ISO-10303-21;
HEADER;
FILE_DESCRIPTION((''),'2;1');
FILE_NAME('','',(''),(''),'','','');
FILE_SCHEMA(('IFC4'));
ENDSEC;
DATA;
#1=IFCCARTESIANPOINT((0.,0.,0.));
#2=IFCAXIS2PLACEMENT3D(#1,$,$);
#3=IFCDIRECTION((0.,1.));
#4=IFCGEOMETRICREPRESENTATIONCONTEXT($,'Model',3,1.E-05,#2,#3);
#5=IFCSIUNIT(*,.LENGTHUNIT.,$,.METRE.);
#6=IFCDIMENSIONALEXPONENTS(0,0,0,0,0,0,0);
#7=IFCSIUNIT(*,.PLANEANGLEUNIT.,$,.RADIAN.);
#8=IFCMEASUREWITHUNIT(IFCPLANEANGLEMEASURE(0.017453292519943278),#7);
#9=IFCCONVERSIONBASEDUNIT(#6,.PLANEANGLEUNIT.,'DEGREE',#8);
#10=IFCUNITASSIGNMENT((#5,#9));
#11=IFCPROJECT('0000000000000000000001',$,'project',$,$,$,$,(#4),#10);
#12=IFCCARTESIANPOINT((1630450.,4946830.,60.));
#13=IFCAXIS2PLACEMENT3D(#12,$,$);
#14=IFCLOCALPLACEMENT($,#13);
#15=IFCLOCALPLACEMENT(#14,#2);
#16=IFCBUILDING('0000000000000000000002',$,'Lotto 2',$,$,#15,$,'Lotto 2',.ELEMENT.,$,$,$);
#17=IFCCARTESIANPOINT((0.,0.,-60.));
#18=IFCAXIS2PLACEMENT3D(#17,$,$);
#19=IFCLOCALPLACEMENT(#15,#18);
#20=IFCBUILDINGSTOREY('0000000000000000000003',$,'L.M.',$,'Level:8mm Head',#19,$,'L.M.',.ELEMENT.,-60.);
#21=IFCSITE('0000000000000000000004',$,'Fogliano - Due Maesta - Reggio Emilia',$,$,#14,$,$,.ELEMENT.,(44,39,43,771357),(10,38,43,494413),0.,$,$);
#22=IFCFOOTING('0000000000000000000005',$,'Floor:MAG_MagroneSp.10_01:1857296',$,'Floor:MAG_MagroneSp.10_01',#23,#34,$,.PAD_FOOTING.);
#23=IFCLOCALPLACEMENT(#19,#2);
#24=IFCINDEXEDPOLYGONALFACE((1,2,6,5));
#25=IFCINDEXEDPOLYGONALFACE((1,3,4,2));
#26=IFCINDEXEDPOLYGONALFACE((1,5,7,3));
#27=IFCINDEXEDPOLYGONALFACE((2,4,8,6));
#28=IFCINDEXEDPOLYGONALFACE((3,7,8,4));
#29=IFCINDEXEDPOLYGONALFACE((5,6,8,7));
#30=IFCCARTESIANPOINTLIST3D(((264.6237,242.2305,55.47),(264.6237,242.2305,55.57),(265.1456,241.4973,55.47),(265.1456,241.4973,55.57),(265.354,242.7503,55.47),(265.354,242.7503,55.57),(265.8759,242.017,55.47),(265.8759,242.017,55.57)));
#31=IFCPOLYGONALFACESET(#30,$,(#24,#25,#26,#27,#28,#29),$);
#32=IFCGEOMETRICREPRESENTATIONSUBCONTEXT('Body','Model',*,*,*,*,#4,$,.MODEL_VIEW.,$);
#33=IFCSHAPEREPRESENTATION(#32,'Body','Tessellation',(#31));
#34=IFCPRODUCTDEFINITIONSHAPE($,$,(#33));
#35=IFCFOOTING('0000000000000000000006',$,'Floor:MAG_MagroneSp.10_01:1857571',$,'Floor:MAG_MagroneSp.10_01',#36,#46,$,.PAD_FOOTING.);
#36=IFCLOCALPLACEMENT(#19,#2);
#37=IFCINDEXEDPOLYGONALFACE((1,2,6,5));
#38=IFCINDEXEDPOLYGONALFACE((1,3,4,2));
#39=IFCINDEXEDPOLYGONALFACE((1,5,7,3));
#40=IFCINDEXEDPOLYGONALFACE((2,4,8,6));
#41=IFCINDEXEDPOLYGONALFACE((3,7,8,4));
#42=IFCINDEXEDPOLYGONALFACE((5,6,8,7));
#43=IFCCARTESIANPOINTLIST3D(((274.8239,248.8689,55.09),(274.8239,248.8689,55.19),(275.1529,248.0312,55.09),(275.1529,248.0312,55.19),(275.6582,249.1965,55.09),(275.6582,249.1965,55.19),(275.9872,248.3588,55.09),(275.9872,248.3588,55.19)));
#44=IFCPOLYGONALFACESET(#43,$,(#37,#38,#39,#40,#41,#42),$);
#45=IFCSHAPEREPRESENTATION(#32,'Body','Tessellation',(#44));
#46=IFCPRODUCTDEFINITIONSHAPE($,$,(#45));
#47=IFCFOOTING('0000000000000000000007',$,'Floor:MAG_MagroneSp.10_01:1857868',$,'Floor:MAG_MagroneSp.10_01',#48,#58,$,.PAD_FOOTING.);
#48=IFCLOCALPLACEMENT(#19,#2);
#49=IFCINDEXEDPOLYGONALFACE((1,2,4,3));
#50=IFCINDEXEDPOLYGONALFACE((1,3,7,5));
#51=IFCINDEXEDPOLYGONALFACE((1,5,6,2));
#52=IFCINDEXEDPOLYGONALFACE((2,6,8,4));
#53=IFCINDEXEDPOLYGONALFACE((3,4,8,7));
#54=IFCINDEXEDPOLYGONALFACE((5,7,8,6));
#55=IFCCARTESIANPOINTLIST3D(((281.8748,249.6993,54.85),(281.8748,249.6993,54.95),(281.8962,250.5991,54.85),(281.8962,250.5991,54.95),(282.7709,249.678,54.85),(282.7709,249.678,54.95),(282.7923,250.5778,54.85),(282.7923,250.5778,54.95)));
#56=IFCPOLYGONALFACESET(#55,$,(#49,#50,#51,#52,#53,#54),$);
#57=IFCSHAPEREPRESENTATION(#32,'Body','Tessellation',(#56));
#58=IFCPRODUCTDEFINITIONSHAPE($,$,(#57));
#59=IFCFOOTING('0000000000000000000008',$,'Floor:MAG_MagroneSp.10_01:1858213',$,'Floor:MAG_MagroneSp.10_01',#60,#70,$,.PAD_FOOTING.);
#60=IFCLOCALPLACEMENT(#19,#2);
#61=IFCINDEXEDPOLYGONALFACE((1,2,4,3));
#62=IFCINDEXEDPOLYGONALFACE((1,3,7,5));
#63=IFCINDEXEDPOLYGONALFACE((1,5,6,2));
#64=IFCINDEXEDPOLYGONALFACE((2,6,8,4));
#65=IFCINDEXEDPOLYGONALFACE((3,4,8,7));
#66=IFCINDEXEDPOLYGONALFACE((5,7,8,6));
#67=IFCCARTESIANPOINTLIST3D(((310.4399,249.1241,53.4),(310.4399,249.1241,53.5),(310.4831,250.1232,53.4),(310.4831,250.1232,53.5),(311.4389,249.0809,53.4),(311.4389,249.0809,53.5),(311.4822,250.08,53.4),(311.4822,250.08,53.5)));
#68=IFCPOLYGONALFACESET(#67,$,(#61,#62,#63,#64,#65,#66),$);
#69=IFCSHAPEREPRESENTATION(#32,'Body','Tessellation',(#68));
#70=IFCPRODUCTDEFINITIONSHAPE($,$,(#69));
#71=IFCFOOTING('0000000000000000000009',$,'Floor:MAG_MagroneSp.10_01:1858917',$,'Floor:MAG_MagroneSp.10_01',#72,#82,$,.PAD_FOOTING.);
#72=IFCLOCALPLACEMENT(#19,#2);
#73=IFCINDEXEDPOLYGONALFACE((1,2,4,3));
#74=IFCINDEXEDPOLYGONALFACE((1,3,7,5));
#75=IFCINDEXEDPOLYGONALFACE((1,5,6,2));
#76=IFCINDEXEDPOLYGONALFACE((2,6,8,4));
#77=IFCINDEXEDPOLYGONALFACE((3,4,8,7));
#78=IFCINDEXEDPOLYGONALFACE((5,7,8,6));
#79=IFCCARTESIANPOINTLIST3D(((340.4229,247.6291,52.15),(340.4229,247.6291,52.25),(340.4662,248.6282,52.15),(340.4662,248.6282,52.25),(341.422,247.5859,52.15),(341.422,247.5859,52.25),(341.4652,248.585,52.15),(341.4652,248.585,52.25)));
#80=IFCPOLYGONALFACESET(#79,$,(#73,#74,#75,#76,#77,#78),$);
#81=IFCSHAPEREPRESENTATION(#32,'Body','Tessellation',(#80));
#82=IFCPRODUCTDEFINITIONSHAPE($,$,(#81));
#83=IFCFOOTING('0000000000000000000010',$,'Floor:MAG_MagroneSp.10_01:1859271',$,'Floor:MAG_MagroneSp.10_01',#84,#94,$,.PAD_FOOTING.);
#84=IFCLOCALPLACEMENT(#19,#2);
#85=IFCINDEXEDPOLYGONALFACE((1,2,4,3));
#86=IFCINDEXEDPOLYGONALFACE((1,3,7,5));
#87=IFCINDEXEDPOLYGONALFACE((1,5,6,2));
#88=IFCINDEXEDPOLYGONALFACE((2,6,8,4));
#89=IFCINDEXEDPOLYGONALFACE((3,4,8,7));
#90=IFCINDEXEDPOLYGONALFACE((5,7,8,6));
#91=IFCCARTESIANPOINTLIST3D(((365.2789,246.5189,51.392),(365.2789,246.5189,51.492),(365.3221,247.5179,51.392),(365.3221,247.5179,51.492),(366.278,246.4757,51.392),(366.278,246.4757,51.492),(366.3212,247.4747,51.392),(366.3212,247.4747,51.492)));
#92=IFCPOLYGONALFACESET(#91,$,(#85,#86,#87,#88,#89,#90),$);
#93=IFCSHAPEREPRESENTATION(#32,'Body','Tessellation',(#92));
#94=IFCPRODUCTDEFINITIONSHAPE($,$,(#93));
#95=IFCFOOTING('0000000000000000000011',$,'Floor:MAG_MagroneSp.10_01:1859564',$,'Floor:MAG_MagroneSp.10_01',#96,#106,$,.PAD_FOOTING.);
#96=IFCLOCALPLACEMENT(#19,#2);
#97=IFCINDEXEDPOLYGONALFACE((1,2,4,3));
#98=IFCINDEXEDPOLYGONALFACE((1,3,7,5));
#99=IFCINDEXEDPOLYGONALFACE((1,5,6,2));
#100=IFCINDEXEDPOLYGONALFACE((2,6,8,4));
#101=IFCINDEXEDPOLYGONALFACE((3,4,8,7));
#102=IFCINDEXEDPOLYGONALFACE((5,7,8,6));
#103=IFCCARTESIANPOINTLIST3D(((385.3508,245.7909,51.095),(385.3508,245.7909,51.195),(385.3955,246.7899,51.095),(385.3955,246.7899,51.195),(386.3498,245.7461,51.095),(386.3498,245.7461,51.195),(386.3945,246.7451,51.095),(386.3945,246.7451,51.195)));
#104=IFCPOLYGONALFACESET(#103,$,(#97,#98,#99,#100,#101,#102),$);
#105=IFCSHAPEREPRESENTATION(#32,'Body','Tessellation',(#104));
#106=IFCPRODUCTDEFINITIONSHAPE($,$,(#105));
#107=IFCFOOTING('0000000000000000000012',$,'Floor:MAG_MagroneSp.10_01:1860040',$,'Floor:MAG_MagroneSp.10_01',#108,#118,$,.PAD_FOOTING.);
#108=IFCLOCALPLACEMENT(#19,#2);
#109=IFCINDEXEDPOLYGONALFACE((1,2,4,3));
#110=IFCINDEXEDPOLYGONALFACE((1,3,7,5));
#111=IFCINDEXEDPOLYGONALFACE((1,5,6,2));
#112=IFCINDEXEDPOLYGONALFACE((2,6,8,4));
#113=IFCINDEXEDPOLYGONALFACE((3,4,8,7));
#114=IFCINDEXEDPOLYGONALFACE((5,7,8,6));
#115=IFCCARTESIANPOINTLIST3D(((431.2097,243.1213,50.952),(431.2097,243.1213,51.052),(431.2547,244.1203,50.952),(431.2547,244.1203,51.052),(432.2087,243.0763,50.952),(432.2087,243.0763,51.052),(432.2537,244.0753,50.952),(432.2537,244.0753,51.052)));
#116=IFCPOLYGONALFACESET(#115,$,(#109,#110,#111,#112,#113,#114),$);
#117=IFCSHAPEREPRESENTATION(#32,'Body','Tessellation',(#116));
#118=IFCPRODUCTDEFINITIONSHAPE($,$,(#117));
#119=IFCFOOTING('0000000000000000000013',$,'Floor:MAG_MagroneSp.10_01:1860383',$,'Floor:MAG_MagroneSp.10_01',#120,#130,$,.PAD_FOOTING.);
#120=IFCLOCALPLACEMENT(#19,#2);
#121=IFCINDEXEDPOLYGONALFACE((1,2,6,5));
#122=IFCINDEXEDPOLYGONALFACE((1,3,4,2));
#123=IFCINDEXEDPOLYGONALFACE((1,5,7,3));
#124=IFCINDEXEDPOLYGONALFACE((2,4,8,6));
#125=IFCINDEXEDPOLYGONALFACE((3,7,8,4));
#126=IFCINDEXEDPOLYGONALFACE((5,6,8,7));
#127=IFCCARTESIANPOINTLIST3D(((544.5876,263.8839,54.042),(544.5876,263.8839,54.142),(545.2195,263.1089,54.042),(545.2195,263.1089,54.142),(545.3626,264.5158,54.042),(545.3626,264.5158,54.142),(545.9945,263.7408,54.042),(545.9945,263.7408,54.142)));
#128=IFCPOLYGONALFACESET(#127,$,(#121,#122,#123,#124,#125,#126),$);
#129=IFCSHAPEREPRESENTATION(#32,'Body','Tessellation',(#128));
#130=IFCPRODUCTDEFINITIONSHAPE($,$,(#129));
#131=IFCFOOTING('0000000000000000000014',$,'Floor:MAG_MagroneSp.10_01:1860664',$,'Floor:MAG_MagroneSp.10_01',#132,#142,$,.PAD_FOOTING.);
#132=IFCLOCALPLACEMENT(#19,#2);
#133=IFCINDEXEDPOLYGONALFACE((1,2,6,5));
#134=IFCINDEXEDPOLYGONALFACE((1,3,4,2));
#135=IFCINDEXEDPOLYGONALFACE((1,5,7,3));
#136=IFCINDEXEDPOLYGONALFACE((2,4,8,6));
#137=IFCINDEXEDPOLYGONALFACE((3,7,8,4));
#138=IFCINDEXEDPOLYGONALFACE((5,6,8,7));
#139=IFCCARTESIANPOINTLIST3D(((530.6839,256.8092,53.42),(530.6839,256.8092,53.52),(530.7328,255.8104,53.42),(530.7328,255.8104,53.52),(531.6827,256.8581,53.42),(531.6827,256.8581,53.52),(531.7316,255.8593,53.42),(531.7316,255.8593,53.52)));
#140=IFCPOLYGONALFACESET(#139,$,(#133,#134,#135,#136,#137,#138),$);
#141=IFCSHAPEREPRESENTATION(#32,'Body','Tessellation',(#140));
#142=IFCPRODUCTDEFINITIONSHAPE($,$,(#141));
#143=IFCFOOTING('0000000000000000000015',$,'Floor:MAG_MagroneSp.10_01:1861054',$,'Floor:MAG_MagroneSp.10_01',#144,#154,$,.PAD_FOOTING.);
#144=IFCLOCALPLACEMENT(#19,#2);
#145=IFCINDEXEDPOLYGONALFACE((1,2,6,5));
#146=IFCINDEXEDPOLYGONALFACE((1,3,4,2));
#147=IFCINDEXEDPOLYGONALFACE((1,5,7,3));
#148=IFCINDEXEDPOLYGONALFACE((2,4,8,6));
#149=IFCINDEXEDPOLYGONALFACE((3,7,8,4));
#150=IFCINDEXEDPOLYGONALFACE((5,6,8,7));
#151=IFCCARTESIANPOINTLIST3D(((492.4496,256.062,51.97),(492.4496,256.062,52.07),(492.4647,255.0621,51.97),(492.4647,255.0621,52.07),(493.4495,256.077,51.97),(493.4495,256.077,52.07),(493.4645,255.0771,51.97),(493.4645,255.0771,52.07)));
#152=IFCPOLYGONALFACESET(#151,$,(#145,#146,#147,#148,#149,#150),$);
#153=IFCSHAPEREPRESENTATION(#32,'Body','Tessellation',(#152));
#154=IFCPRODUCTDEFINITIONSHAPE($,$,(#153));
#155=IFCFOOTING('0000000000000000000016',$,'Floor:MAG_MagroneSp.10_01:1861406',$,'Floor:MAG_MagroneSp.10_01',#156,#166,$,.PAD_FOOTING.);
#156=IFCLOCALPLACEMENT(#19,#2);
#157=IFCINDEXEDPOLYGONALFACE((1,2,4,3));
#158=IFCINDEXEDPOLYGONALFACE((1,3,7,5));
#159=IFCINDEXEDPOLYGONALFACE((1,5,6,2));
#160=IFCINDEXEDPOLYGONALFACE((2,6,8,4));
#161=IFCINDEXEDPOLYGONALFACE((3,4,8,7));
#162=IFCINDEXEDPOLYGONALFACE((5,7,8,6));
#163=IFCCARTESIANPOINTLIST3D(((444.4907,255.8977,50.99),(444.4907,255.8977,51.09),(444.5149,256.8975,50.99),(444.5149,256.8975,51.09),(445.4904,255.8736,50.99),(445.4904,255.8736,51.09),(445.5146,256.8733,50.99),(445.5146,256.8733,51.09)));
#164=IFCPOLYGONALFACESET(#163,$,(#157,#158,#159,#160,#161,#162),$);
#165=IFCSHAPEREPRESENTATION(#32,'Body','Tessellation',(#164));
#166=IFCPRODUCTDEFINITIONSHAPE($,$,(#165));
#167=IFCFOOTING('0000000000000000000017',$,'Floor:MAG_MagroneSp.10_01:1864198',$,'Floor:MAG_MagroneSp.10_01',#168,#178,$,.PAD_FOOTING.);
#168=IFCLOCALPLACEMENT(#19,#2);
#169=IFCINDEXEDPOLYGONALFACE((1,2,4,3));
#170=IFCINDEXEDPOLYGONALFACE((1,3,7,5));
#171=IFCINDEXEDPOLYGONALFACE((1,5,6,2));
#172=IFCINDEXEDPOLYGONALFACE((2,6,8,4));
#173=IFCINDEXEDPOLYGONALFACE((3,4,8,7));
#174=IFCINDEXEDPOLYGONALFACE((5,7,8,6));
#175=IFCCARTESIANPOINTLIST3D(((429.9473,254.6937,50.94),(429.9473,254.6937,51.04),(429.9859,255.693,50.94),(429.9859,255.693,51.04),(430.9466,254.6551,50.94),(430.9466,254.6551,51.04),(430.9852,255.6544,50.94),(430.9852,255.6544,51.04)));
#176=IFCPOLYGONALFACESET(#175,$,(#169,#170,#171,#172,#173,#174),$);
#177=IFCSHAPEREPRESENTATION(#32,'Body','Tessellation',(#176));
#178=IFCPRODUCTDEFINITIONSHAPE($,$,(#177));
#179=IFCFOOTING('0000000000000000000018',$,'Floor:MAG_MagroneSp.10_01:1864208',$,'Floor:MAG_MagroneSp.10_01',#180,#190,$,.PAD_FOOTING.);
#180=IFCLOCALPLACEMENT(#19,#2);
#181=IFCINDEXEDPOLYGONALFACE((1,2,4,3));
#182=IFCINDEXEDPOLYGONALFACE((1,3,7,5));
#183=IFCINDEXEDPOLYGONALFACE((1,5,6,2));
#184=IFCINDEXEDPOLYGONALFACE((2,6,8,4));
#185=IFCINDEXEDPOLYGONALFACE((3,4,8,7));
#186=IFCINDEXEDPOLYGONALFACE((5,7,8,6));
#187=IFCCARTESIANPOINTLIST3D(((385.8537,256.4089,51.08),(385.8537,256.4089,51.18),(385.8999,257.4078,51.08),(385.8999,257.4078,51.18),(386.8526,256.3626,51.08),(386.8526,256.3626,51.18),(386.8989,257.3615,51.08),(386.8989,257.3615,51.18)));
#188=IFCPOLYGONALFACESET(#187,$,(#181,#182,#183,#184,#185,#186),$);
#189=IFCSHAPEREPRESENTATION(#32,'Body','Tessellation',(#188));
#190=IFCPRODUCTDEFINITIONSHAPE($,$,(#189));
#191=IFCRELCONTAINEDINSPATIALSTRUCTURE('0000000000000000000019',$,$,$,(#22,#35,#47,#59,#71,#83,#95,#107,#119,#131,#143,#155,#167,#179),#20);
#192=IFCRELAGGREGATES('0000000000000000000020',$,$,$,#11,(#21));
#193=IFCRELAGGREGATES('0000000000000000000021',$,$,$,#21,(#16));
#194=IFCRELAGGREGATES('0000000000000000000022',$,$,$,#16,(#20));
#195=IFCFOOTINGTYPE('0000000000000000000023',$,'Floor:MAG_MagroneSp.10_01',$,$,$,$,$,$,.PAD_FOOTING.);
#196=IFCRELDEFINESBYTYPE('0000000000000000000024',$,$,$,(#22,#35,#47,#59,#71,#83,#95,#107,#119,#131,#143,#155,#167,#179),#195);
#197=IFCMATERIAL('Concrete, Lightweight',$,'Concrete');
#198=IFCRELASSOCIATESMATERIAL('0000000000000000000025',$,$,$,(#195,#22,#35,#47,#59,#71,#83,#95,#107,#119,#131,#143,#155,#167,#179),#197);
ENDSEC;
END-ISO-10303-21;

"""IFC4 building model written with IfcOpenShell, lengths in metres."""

from ifc_helpers import new_model, entity, si_unit, converted_unit, direction, frame, origin, place, context, subcontext, project, spatial, indexed_curve, outline, extrude, material, type_object, element, save


model = new_model("IFC4")

# Units and contexts
model_context = context("Model", 3, precision=1e-05, world=origin(), true_north=direction((0.0, 1.0)))
body_context = subcontext(model_context, "Body", "Model", "MODEL_VIEW")
ifc_project = project(units=[si_unit("LENGTHUNIT", "METRE"), converted_unit("PLANEANGLEUNIT", "DEGREE", entity("IfcPlaneAngleMeasure", 0.017453292519943278), si_unit("PLANEANGLEUNIT", "RADIAN"), dimensions=[0, 0, 0, 0, 0, 0, 0])], contexts=[model_context])

# Site, building, storey
site_placement = place(None, frame((1630450.0, 4946830.0, 60.0)))
site = spatial("IfcSite", under=ifc_project, at=site_placement, Name="Fogliano - Due Maesta - Reggio Emilia", CompositionType="ELEMENT", RefLatitude=(44, 39, 43, 771357), RefLongitude=(10, 38, 43, 494413), RefElevation=0.0)
building_placement = place(site_placement, origin())
building = spatial("IfcBuilding", under=site, at=building_placement, Name="Lotto 2", LongName="Lotto 2", CompositionType="ELEMENT")
storey_placement = place(building_placement, frame((0.0, 0.0, -60.0)))
storey = spatial("IfcBuildingStorey", under=building, at=storey_placement, Name="L.M.", ObjectType="Level:8mm Head", LongName="L.M.", CompositionType="ELEMENT", Elevation=-60.0)

# Footings
ifc_material = material(Name="Concrete, Lightweight", Category="Concrete")
footing_type = type_object("IfcFootingType", Name="Floor:MAG_MagroneSp.10_01", PredefinedType="PAD_FOOTING", material=ifc_material)
footing_1_placement = place(storey_placement, origin())
element("IfcFooting", 1, at=footing_1_placement, inside=storey, type_object=footing_type, material=ifc_material, Name="Floor:MAG_MagroneSp.10_01:1857296", ObjectType="Floor:MAG_MagroneSp.10_01", PredefinedType="PAD_FOOTING", context=body_context, shape_type="SweptSolid", body=[
    extrude(outline(indexed_curve([(-0.45, -0.4482), (0.45, -0.4482), (0.45, 0.4482), (-0.45, 0.4482), (-0.45, -0.4482)], self_intersect=False)), frame((265.2498, 242.1238, 55.57), z_axis=(0.0, 0.0, -1.0), x_axis=(0.579841, -0.81473, 0.0)), (0.0, 0.0, 1.0), 0.1),
])
footing_2_placement = place(storey_placement, origin())
element("IfcFooting", 2, at=footing_2_placement, inside=storey, type_object=footing_type, material=ifc_material, Name="Floor:MAG_MagroneSp.10_01:1857571", ObjectType="Floor:MAG_MagroneSp.10_01", PredefinedType="PAD_FOOTING", context=body_context, shape_type="SweptSolid", body=[
    extrude(outline(indexed_curve([(-0.45, -0.4482), (0.45, -0.4482), (0.45, 0.4482), (-0.45, 0.4482), (-0.45, -0.4482)], self_intersect=False)), frame((275.4056, 248.6139, 55.19), z_axis=(0.0, 0.0, -1.0), x_axis=(0.365516, -0.930805, 0.0)), (0.0, 0.0, 1.0), 0.1),
])
footing_3_placement = place(storey_placement, origin())
element("IfcFooting", 3, at=footing_3_placement, inside=storey, type_object=footing_type, material=ifc_material, Name="Floor:MAG_MagroneSp.10_01:1857868", ObjectType="Floor:MAG_MagroneSp.10_01", PredefinedType="PAD_FOOTING", context=body_context, shape_type="SweptSolid", body=[
    extrude(outline(indexed_curve([(-0.45, -0.4482), (0.45, -0.4482), (0.45, 0.4482), (-0.45, 0.4482), (-0.45, -0.4482)], self_intersect=False)), frame((282.3335, 250.1385, 54.95), z_axis=(0.0, 0.0, -1.0), x_axis=(-0.023751, -0.999718, 0.0)), (0.0, 0.0, 1.0), 0.1),
])
footing_4_placement = place(storey_placement, origin())
element("IfcFooting", 4, at=footing_4_placement, inside=storey, type_object=footing_type, material=ifc_material, Name="Floor:MAG_MagroneSp.10_01:1858213", ObjectType="Floor:MAG_MagroneSp.10_01", PredefinedType="PAD_FOOTING", context=body_context, shape_type="SweptSolid", body=[
    extrude(outline(indexed_curve([(-0.5, -0.5), (0.5, -0.5), (0.5, 0.5), (-0.5, 0.5), (-0.5, -0.5)], self_intersect=False)), frame((310.961, 249.6021, 53.5), z_axis=(0.0, 0.0, -1.0), x_axis=(-0.043221, -0.999066, 0.0)), (0.0, 0.0, 1.0), 0.1),
])
footing_5_placement = place(storey_placement, origin())
element("IfcFooting", 5, at=footing_5_placement, inside=storey, type_object=footing_type, material=ifc_material, Name="Floor:MAG_MagroneSp.10_01:1858917", ObjectType="Floor:MAG_MagroneSp.10_01", PredefinedType="PAD_FOOTING", context=body_context, shape_type="SweptSolid", body=[
    extrude(outline(indexed_curve([(-0.5, -0.5), (0.5, -0.5), (0.5, 0.5), (-0.5, 0.5), (-0.5, -0.5)], self_intersect=False)), frame((340.9441, 248.1071, 52.25), z_axis=(0.0, 0.0, -1.0), x_axis=(-0.043221, -0.999066, 0.0)), (0.0, 0.0, 1.0), 0.1),
])
footing_6_placement = place(storey_placement, origin())
element("IfcFooting", 6, at=footing_6_placement, inside=storey, type_object=footing_type, material=ifc_material, Name="Floor:MAG_MagroneSp.10_01:1859271", ObjectType="Floor:MAG_MagroneSp.10_01", PredefinedType="PAD_FOOTING", context=body_context, shape_type="SweptSolid", body=[
    extrude(outline(indexed_curve([(-0.5, -0.5), (0.5, -0.5), (0.5, 0.5), (-0.5, 0.5), (-0.5, -0.5)], self_intersect=False)), frame((365.8001, 246.9968, 51.492), z_axis=(0.0, 0.0, -1.0), x_axis=(-0.043221, -0.999066, 0.0)), (0.0, 0.0, 1.0), 0.1),
])
footing_7_placement = place(storey_placement, origin())
element("IfcFooting", 7, at=footing_7_placement, inside=storey, type_object=footing_type, material=ifc_material, Name="Floor:MAG_MagroneSp.10_01:1859564", ObjectType="Floor:MAG_MagroneSp.10_01", PredefinedType="PAD_FOOTING", context=body_context, shape_type="SweptSolid", body=[
    extrude(outline(indexed_curve([(-0.5, -0.5), (0.5, -0.5), (0.5, 0.5), (-0.5, 0.5), (-0.5, -0.5)], self_intersect=False)), frame((385.8726, 246.268, 51.195), z_axis=(0.0, 0.0, -1.0), x_axis=(-0.044742, -0.998999, 0.0)), (0.0, 0.0, 1.0), 0.1),
])
footing_8_placement = place(storey_placement, origin())
element("IfcFooting", 8, at=footing_8_placement, inside=storey, type_object=footing_type, material=ifc_material, Name="Floor:MAG_MagroneSp.10_01:1860040", ObjectType="Floor:MAG_MagroneSp.10_01", PredefinedType="PAD_FOOTING", context=body_context, shape_type="SweptSolid", body=[
    extrude(outline(indexed_curve([(-0.5, -0.5), (0.5, -0.5), (0.5, 0.5), (-0.5, 0.5), (-0.5, -0.5)], self_intersect=False)), frame((431.7317, 243.5983, 51.052), z_axis=(0.0, 0.0, -1.0), x_axis=(-0.044984, -0.998988, 0.0)), (0.0, 0.0, 1.0), 0.1),
])
footing_9_placement = place(storey_placement, origin())
element("IfcFooting", 9, at=footing_9_placement, inside=storey, type_object=footing_type, material=ifc_material, Name="Floor:MAG_MagroneSp.10_01:1860383", ObjectType="Floor:MAG_MagroneSp.10_01", PredefinedType="PAD_FOOTING", context=body_context, shape_type="SweptSolid", body=[
    extrude(outline(indexed_curve([(-0.5, -0.5), (0.5, -0.5), (0.5, 0.5), (-0.5, 0.5), (-0.5, -0.5)], self_intersect=False)), frame((545.2911, 263.8123, 54.142), z_axis=(0.0, 0.0, -1.0), x_axis=(0.631893, -0.775056, 0.0)), (0.0, 0.0, 1.0), 0.1),
])
footing_10_placement = place(storey_placement, origin())
element("IfcFooting", 10, at=footing_10_placement, inside=storey, type_object=footing_type, material=ifc_material, Name="Floor:MAG_MagroneSp.10_01:1860664", ObjectType="Floor:MAG_MagroneSp.10_01", PredefinedType="PAD_FOOTING", context=body_context, shape_type="SweptSolid", body=[
    extrude(outline(indexed_curve([(-0.5, -0.5), (0.5, -0.5), (0.5, 0.5), (-0.5, 0.5), (-0.5, -0.5)], self_intersect=False)), frame((531.2078, 256.3342, 53.52), z_axis=(0.0, 0.0, -1.0), x_axis=(0.048894, -0.998804, 0.0)), (0.0, 0.0, 1.0), 0.1),
])
footing_11_placement = place(storey_placement, origin())
element("IfcFooting", 11, at=footing_11_placement, inside=storey, type_object=footing_type, material=ifc_material, Name="Floor:MAG_MagroneSp.10_01:1861054", ObjectType="Floor:MAG_MagroneSp.10_01", PredefinedType="PAD_FOOTING", context=body_context, shape_type="SweptSolid", body=[
    extrude(outline(indexed_curve([(-0.5, -0.5), (0.5, -0.5), (0.5, 0.5), (-0.5, 0.5), (-0.5, -0.5)], self_intersect=False)), frame((492.9571, 255.5695, 52.07), z_axis=(0.0, 0.0, -1.0), x_axis=(0.01503, -0.999887, 0.0)), (0.0, 0.0, 1.0), 0.1),
])
footing_12_placement = place(storey_placement, origin())
element("IfcFooting", 12, at=footing_12_placement, inside=storey, type_object=footing_type, material=ifc_material, Name="Floor:MAG_MagroneSp.10_01:1861406", ObjectType="Floor:MAG_MagroneSp.10_01", PredefinedType="PAD_FOOTING", context=body_context, shape_type="SweptSolid", body=[
    extrude(outline(indexed_curve([(-0.5, -0.5), (0.5, -0.5), (0.5, 0.5), (-0.5, 0.5), (-0.5, -0.5)], self_intersect=False)), frame((445.0026, 256.3855, 51.09), z_axis=(0.0, 0.0, -1.0), x_axis=(-0.024162, -0.999708, 0.0)), (0.0, 0.0, 1.0), 0.1),
])
footing_13_placement = place(storey_placement, origin())
element("IfcFooting", 13, at=footing_13_placement, inside=storey, type_object=footing_type, material=ifc_material, Name="Floor:MAG_MagroneSp.10_01:1864198", ObjectType="Floor:MAG_MagroneSp.10_01", PredefinedType="PAD_FOOTING", context=body_context, shape_type="SweptSolid", body=[
    extrude(outline(indexed_curve([(-0.5, -0.5), (0.5, -0.5), (0.5, 0.5), (-0.5, 0.5), (-0.5, -0.5)], self_intersect=False)), frame((430.4662, 255.174, 51.04), z_axis=(0.0, 0.0, -1.0), x_axis=(-0.038597, -0.999255, 0.0)), (0.0, 0.0, 1.0), 0.1),
])
footing_14_placement = place(storey_placement, origin())
element("IfcFooting", 14, at=footing_14_placement, inside=storey, type_object=footing_type, material=ifc_material, Name="Floor:MAG_MagroneSp.10_01:1864208", ObjectType="Floor:MAG_MagroneSp.10_01", PredefinedType="PAD_FOOTING", context=body_context, shape_type="SweptSolid", body=[
    extrude(outline(indexed_curve([(-0.5, -0.5), (0.5, -0.5), (0.5, 0.5), (-0.5, 0.5), (-0.5, -0.5)], self_intersect=False)), frame((386.3763, 256.8852, 51.18), z_axis=(0.0, 0.0, -1.0), x_axis=(-0.046292, -0.998928, 0.0)), (0.0, 0.0, 1.0), 0.1),
])

save(model, "model.ifc")
